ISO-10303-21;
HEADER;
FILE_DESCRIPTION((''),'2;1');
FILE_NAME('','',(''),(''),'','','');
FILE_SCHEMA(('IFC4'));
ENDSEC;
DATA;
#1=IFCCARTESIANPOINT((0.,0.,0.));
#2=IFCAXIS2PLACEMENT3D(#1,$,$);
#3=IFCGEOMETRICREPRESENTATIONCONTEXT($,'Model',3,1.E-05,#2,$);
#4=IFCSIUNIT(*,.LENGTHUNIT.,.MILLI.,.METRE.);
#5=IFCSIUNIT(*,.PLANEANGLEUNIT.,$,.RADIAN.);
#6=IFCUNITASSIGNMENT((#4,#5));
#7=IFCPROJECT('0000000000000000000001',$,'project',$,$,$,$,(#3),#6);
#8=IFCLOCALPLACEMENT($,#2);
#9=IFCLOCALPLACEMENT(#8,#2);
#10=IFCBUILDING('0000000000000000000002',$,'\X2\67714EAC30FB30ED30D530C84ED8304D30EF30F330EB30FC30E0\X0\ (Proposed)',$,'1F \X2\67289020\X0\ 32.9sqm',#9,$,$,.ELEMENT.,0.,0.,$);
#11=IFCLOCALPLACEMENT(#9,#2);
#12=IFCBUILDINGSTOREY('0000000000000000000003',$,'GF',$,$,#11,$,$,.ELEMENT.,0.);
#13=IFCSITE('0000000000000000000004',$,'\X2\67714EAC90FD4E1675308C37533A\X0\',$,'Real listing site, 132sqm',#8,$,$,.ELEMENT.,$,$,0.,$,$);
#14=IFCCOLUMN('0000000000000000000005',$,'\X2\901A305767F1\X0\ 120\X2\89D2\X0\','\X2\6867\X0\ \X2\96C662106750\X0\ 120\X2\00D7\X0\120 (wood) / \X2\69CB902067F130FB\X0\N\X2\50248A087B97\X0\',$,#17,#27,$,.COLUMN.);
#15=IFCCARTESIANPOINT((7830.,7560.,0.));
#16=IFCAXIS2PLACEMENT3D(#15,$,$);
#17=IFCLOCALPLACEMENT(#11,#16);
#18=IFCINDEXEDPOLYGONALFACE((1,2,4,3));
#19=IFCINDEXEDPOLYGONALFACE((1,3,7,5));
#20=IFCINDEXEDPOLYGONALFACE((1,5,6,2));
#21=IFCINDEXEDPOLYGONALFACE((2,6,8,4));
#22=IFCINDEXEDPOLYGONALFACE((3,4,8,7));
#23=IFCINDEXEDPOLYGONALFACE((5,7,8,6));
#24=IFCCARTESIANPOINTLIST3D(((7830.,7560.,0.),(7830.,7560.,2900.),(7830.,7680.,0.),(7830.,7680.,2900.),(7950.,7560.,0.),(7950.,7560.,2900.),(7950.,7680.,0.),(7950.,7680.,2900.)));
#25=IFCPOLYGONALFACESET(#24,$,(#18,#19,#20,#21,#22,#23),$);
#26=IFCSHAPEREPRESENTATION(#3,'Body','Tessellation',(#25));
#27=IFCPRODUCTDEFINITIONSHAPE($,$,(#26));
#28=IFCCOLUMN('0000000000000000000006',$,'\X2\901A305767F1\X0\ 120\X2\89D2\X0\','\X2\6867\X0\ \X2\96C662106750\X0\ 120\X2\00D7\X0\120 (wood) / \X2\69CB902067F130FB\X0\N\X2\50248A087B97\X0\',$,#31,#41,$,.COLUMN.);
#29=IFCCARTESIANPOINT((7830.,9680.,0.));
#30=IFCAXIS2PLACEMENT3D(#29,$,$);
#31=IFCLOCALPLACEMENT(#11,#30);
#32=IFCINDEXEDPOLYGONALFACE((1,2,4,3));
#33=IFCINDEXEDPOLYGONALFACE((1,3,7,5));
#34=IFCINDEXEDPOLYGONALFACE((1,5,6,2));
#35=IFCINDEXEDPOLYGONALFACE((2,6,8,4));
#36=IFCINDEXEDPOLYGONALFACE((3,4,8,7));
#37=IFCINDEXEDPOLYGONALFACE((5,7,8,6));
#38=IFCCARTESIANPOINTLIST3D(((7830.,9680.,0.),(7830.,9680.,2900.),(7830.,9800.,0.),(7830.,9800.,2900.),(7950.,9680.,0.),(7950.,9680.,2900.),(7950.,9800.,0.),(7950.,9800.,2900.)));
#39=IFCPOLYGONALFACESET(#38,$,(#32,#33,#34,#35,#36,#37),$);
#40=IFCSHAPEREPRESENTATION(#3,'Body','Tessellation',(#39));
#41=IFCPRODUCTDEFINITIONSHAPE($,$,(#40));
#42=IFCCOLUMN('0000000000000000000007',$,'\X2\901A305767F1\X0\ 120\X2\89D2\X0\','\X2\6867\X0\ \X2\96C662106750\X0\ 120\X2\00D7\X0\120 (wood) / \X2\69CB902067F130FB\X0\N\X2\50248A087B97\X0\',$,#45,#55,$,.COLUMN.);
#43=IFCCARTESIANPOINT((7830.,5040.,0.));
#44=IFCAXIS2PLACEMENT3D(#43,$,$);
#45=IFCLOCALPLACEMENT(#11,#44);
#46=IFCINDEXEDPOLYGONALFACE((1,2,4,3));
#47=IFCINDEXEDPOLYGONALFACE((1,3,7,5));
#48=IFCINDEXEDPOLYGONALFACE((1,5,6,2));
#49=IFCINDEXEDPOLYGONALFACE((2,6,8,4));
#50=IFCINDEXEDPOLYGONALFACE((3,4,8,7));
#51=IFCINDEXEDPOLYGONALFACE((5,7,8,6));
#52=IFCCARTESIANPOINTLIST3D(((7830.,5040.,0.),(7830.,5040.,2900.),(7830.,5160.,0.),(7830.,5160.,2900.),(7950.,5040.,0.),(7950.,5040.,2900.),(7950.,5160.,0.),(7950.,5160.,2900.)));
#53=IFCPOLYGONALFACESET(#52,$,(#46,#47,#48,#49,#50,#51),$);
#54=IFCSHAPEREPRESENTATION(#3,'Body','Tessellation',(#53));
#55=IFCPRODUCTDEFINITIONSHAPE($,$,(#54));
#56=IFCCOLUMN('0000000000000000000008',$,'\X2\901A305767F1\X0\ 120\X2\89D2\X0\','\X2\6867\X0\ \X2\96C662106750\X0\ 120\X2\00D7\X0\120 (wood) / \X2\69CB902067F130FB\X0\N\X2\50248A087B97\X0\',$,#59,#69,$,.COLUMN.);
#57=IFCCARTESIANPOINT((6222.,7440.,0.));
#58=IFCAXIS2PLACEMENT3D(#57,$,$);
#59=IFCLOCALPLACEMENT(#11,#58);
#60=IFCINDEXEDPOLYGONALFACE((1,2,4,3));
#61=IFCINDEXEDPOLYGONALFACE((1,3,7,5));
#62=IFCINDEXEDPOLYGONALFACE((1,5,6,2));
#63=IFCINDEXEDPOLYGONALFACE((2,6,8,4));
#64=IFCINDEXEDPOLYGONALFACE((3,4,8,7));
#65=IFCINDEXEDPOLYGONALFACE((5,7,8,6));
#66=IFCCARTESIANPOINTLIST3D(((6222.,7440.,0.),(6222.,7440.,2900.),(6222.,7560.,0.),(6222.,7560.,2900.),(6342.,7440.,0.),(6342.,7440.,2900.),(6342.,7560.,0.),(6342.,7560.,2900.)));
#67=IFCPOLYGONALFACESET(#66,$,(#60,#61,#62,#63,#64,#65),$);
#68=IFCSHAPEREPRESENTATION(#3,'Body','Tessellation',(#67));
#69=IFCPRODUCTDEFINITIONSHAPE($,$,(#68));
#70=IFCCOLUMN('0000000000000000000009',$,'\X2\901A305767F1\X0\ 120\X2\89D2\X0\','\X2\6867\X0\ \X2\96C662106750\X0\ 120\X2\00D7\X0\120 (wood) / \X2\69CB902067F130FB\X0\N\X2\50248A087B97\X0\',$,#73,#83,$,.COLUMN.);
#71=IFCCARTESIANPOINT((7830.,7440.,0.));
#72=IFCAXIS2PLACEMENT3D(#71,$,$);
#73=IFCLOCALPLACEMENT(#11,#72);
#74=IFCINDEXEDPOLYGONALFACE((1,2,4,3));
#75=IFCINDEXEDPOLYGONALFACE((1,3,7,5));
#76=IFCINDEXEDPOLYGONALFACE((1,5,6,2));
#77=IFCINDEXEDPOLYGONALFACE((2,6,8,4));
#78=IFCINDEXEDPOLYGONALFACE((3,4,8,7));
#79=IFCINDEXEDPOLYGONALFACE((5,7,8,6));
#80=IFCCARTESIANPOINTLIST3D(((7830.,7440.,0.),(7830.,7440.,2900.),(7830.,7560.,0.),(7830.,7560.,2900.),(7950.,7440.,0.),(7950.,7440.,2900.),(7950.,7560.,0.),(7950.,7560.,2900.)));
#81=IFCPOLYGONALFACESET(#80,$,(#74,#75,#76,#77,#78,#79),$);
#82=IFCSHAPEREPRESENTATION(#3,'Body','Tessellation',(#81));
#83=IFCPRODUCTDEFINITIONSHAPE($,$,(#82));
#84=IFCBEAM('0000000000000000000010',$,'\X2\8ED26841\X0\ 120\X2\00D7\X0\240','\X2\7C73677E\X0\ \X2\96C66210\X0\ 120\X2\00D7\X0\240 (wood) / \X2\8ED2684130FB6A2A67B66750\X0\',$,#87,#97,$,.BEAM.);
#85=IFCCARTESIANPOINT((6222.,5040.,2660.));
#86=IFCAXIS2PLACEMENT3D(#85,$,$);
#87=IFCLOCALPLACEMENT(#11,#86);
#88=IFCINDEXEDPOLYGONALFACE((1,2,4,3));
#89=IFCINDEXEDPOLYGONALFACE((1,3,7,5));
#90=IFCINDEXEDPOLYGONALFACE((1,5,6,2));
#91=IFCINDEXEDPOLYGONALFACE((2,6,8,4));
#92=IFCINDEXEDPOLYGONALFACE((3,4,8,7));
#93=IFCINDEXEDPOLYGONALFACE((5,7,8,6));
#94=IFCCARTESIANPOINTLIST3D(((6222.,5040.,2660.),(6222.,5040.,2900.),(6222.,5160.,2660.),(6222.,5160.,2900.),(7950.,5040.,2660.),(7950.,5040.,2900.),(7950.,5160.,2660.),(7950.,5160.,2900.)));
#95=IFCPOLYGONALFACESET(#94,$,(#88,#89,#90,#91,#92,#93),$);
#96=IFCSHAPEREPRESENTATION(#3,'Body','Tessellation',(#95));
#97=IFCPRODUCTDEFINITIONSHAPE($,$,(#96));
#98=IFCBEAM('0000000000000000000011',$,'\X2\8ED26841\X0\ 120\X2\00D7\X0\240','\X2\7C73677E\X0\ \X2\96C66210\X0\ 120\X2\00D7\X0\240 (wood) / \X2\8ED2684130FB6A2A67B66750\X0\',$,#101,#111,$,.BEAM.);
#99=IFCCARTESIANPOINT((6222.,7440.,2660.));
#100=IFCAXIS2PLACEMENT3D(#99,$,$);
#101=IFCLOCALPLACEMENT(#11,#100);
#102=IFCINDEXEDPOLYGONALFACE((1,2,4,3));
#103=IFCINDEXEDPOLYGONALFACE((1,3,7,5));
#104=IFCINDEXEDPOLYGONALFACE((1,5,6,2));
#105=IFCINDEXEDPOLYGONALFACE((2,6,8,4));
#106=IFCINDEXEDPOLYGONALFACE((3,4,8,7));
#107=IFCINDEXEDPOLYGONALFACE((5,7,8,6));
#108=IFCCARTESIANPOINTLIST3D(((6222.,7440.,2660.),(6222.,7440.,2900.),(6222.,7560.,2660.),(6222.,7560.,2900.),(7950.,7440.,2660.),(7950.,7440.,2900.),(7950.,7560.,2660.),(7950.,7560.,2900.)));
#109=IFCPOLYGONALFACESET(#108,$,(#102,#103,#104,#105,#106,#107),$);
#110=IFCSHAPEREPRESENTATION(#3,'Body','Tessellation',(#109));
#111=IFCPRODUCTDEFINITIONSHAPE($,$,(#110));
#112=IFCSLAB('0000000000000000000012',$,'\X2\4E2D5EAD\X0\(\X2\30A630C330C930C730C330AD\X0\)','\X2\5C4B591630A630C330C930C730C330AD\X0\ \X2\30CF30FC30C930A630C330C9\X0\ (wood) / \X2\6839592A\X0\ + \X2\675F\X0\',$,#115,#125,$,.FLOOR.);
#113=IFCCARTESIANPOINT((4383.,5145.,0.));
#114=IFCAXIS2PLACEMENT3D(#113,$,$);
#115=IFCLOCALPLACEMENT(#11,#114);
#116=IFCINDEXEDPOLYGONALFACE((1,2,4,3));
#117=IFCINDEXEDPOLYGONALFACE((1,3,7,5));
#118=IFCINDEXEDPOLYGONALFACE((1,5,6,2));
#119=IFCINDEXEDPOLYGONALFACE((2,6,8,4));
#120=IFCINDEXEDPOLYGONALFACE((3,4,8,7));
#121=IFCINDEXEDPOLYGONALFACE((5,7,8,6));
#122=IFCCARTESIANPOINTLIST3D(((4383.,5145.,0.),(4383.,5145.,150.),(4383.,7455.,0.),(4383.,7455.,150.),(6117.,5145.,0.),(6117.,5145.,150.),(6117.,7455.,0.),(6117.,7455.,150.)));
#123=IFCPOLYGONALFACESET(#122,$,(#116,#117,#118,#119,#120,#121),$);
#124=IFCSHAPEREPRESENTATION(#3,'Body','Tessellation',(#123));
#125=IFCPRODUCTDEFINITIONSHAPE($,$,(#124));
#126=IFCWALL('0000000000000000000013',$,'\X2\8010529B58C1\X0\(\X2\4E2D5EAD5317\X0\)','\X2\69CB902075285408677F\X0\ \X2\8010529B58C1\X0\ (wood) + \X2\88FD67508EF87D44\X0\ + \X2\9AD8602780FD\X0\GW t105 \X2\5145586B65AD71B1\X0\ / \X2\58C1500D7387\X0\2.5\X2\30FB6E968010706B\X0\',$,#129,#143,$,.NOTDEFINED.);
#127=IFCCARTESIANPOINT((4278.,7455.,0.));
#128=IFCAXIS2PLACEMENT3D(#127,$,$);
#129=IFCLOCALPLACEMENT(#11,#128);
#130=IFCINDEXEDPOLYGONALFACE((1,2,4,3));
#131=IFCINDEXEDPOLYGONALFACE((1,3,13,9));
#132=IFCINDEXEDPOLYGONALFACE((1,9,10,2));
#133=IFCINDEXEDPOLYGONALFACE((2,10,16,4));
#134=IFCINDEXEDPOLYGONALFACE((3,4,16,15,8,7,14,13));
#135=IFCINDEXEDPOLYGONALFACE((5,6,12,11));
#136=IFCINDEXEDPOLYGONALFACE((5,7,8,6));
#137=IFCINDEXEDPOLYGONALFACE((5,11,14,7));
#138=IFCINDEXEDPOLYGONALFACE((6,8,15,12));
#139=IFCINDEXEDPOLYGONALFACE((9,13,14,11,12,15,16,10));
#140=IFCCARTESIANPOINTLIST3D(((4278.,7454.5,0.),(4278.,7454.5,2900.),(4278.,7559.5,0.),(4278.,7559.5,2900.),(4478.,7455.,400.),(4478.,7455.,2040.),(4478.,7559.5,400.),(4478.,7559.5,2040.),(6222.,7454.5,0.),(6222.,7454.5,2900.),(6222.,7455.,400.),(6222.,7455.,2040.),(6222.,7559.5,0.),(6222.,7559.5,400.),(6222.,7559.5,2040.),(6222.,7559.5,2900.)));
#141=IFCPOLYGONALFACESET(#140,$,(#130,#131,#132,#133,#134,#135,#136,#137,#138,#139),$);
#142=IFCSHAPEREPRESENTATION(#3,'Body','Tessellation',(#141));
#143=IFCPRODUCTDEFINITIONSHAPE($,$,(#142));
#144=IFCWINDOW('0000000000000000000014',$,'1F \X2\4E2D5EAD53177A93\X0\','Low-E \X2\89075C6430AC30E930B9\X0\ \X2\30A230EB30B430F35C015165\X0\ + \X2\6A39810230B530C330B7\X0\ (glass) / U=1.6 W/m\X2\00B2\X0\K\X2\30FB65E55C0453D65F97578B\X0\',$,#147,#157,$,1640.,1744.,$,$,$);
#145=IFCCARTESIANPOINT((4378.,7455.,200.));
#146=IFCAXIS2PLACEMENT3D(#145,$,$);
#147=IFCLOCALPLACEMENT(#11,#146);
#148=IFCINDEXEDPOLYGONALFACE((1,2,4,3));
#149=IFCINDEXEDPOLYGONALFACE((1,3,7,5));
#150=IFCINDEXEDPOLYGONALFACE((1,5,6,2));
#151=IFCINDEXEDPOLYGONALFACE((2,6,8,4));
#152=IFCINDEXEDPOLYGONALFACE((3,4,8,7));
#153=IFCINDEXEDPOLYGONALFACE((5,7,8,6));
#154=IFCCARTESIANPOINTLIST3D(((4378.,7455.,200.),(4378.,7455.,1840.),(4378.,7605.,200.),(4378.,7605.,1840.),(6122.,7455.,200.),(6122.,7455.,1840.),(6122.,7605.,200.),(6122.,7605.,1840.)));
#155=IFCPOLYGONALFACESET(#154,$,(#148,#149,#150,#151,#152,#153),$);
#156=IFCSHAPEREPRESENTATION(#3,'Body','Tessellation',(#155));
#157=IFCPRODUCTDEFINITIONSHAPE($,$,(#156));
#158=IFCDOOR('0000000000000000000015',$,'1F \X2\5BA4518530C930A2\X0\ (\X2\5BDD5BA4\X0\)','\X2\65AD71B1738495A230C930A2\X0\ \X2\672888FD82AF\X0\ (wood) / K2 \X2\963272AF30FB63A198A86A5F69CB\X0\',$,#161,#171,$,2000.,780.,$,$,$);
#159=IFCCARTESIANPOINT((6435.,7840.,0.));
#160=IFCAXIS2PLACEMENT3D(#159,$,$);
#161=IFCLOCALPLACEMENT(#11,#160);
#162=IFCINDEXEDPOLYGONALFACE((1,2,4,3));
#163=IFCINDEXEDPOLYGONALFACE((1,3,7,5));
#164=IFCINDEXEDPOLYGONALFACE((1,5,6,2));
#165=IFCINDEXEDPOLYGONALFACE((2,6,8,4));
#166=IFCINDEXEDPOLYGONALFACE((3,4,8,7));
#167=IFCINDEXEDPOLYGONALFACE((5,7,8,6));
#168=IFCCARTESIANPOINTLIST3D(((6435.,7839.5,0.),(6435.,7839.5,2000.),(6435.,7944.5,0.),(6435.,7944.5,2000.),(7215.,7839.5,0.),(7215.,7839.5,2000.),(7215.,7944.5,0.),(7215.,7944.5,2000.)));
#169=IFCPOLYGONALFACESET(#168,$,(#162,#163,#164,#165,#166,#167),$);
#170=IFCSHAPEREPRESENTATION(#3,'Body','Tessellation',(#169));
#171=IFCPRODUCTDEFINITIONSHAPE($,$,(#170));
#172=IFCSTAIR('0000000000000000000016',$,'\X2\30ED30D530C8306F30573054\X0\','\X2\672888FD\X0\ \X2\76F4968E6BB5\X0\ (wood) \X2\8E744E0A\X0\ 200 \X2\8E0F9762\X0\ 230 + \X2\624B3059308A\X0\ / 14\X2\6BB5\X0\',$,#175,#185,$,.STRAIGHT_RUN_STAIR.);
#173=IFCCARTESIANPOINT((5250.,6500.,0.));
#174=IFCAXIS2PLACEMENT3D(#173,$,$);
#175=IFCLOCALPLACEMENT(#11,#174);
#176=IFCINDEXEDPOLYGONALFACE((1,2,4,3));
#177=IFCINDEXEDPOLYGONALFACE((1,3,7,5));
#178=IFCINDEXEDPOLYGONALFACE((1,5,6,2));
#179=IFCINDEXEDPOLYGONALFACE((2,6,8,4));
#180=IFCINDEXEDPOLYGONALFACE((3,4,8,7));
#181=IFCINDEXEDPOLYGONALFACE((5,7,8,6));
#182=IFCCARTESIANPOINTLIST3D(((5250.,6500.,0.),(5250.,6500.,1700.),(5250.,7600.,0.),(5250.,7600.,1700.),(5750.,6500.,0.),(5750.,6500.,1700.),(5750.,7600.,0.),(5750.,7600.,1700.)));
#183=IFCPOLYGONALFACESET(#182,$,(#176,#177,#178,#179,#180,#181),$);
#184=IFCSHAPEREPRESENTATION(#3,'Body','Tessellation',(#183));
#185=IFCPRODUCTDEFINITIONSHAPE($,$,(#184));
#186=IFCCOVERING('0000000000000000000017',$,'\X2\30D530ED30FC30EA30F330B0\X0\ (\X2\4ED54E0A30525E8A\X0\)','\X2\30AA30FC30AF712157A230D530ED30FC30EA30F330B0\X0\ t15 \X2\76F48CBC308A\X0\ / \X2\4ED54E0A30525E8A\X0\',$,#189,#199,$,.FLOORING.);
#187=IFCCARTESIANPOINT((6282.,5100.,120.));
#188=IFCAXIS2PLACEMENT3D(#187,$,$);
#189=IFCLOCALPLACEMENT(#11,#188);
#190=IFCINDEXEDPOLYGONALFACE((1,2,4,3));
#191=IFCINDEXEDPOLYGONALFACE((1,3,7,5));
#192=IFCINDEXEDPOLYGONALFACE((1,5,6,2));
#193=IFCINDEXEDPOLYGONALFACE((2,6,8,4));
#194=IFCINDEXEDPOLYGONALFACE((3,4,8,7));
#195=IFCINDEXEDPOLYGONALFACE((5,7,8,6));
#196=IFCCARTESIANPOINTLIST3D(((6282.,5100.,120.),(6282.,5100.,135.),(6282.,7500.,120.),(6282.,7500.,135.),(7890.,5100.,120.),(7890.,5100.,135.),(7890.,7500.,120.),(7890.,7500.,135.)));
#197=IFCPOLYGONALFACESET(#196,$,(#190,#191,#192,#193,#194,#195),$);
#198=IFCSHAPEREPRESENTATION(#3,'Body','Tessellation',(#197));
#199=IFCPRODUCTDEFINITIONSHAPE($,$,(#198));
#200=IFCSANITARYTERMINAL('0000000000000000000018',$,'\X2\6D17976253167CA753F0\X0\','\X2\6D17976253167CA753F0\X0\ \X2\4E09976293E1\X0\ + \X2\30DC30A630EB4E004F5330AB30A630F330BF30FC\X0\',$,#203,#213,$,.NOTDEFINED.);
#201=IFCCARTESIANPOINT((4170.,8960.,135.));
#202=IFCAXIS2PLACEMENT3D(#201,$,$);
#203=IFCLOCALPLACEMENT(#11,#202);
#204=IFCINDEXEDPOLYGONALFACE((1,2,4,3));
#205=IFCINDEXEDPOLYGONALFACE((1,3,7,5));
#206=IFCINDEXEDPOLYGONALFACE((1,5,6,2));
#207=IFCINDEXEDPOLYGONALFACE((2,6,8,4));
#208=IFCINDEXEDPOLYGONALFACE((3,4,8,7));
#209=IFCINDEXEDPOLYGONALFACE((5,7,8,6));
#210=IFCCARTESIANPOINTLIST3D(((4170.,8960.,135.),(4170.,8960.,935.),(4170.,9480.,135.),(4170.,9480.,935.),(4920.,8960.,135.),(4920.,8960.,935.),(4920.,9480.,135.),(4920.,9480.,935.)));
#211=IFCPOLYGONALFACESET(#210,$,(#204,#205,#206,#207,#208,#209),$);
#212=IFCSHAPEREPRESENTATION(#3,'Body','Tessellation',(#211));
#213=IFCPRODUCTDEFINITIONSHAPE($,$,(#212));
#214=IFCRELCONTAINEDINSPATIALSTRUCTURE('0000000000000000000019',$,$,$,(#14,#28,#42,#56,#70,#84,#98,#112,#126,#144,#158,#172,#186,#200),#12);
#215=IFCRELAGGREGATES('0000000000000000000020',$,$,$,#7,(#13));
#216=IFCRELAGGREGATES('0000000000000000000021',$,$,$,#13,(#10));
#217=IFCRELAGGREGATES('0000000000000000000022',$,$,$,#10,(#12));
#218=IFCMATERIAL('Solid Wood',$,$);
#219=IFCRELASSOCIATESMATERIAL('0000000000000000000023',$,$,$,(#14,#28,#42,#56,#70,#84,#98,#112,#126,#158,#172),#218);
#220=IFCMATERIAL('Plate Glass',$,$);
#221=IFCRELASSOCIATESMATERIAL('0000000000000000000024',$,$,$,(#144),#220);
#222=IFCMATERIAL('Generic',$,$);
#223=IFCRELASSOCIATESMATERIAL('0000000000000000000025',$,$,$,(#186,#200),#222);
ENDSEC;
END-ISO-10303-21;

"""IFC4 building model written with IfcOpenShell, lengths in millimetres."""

from ifc_helpers import new_model, si_unit, frame, frame_2d, origin, place, context, project, spatial, rectangle, extrude, material, element, fill, save


model = new_model("IFC4")

# Units and contexts
model_context = context("Model", 3, precision=1e-05, world=origin())
ifc_project = project(units=[si_unit("LENGTHUNIT", "METRE", prefix="MILLI"), si_unit("PLANEANGLEUNIT", "RADIAN")], contexts=[model_context])

# Site, building, storey
site_placement = place(None, origin())
site = spatial("IfcSite", under=ifc_project, at=site_placement, Name="東京都世田谷区", ObjectType="Real listing site, 132sqm", CompositionType="ELEMENT", RefElevation=0.0)
building_placement = place(site_placement, origin())
building = spatial("IfcBuilding", under=site, at=building_placement, Name="東京・ロフト付きワンルーム (Proposed)", ObjectType="1F 木造 32.9sqm", CompositionType="ELEMENT", ElevationOfRefHeight=0.0, ElevationOfTerrain=0.0)
storey_placement = place(building_placement, origin())
storey = spatial("IfcBuildingStorey", under=building, at=storey_placement, Name="GF", CompositionType="ELEMENT", Elevation=0.0)

# Columns
ifc_material_1 = material(Name="Solid Wood")
column_1_placement = place(storey_placement, frame((7830.0, 7560.0, 0.0)))
element("IfcColumn", 1, at=column_1_placement, inside=storey, material=ifc_material_1, Name="通し柱 120角", Description="桧 集成材 120×120 (wood) / 構造柱・N値計算", PredefinedType="COLUMN", context=model_context, shape_type="SweptSolid", body=[
    extrude(rectangle(XDim=120.0, YDim=120.0, at=frame_2d((60.0, 60.0))), frame((7830.0, 7560.0, 0.0)), (0.0, 0.0, 1.0), 2900.0),
])
column_2_placement = place(storey_placement, frame((7830.0, 9680.0, 0.0)))
element("IfcColumn", 2, at=column_2_placement, inside=storey, material=ifc_material_1, Name="通し柱 120角", Description="桧 集成材 120×120 (wood) / 構造柱・N値計算", PredefinedType="COLUMN", context=model_context, shape_type="SweptSolid", body=[
    extrude(rectangle(XDim=120.0, YDim=120.0, at=frame_2d((60.0, 60.0))), frame((7830.0, 9680.0, 0.0)), (0.0, 0.0, 1.0), 2900.0),
])
column_3_placement = place(storey_placement, frame((7830.0, 5040.0, 0.0)))
element("IfcColumn", 3, at=column_3_placement, inside=storey, material=ifc_material_1, Name="通し柱 120角", Description="桧 集成材 120×120 (wood) / 構造柱・N値計算", PredefinedType="COLUMN", context=model_context, shape_type="SweptSolid", body=[
    extrude(rectangle(XDim=120.0, YDim=120.0, at=frame_2d((60.0, 60.0))), frame((7830.0, 5040.0, 0.0)), (0.0, 0.0, 1.0), 2900.0),
])
column_4_placement = place(storey_placement, frame((6222.0, 7440.0, 0.0)))
element("IfcColumn", 4, at=column_4_placement, inside=storey, material=ifc_material_1, Name="通し柱 120角", Description="桧 集成材 120×120 (wood) / 構造柱・N値計算", PredefinedType="COLUMN", context=model_context, shape_type="SweptSolid", body=[
    extrude(rectangle(XDim=120.0, YDim=120.0, at=frame_2d((60.0, 60.0))), frame((6222.0, 7440.0, 0.0)), (0.0, 0.0, 1.0), 2900.0),
])
column_5_placement = place(storey_placement, frame((7830.0, 7440.0, 0.0)))
element("IfcColumn", 5, at=column_5_placement, inside=storey, material=ifc_material_1, Name="通し柱 120角", Description="桧 集成材 120×120 (wood) / 構造柱・N値計算", PredefinedType="COLUMN", context=model_context, shape_type="SweptSolid", body=[
    extrude(rectangle(XDim=120.0, YDim=120.0, at=frame_2d((60.0, 60.0))), frame((7830.0, 7440.0, 0.0)), (0.0, 0.0, 1.0), 2900.0),
])

# Beams
beam_1_placement = place(storey_placement, frame((6222.0, 5040.0, 2660.0)))
element("IfcBeam", 6, at=beam_1_placement, inside=storey, material=ifc_material_1, Name="軒桁 120×240", Description="米松 集成 120×240 (wood) / 軒桁・横架材", PredefinedType="BEAM", context=model_context, shape_type="SweptSolid", body=[
    extrude(rectangle(XDim=1728.0, YDim=120.0, at=frame_2d((864.0, 60.0))), frame((6222.0, 5040.0, 2660.0)), (0.0, 0.0, 1.0), 240.0),
])
beam_2_placement = place(storey_placement, frame((6222.0, 7440.0, 2660.0)))
element("IfcBeam", 7, at=beam_2_placement, inside=storey, material=ifc_material_1, Name="軒桁 120×240", Description="米松 集成 120×240 (wood) / 軒桁・横架材", PredefinedType="BEAM", context=model_context, shape_type="SweptSolid", body=[
    extrude(rectangle(XDim=1728.0, YDim=120.0, at=frame_2d((864.0, 60.0))), frame((6222.0, 7440.0, 2660.0)), (0.0, 0.0, 1.0), 240.0),
])

# Slab
slab_placement = place(storey_placement, frame((4383.0, 5145.0, 0.0)))
element("IfcSlab", 8, at=slab_placement, inside=storey, material=ifc_material_1, Name="中庭(ウッドデッキ)", Description="屋外ウッドデッキ ハードウッド (wood) / 根太 + 束", PredefinedType="FLOOR", context=model_context, shape_type="SweptSolid", body=[
    extrude(rectangle(XDim=1734.0, YDim=2310.0, at=frame_2d((867.0, 1155.0))), frame((4383.0, 5145.0, 0.0)), (0.0, 0.0, 1.0), 150.0),
])

# Wall, opening, window
wall_1_placement = place(storey_placement, frame((4278.0, 7455.0, 0.0)))
wall_1 = element("IfcWall", 9, at=wall_1_placement, inside=storey, material=ifc_material_1, Name="耐力壁(中庭北)", Description="構造用合板 耐力壁 (wood) + 製材軸組 + 高性能GW t105 充填断熱 / 壁倍率2.5・準耐火", PredefinedType="NOTDEFINED", context=model_context, shape_type="SweptSolid", body=[
    extrude(rectangle(XDim=1944.0, YDim=105.0, at=frame_2d((972.0, 52.0))), frame((4278.0, 7455.0, 0.0)), (0.0, 0.0, 1.0), 2900.0),
])
opening_placement = place(storey_placement, frame((4378.0, 7455.0, 200.0)))
opening = element("IfcOpeningElement", 10, at=opening_placement, cuts=wall_1, PredefinedType="NOTDEFINED", context=model_context, shape_type="SweptSolid", body=[
    extrude(rectangle(XDim=1744.0, YDim=150.0, at=frame_2d((872.0, 75.0))), frame((4378.0, 7455.0, 200.0)), (0.0, 0.0, 1.0), 1640.0),
])
ifc_material_2 = material(Name="Plate Glass")
window_placement = place(storey_placement, frame((4378.0, 7455.0, 200.0)))
window = element("IfcWindow", 11, at=window_placement, inside=storey, material=ifc_material_2, Name="1F 中庭北窓", Description="Low-E 複層ガラス アルゴン封入 + 樹脂サッシ (glass) / U=1.6 W/m²K・日射取得型", OverallHeight=1640.0, OverallWidth=1744.0, context=model_context, shape_type="SweptSolid", body=[
    extrude(rectangle(XDim=1744.0, YDim=150.0, at=frame_2d((872.0, 75.0))), frame((4378.0, 7455.0, 200.0)), (0.0, 0.0, 1.0), 1640.0),
])
fill(opening, window)

# Door
door_placement = place(storey_placement, frame((6435.0, 7840.0, 0.0)))
element("IfcDoor", 12, at=door_placement, inside=storey, material=ifc_material_1, Name="1F 室内ドア (寝室)", Description="断熱玄関ドア 木製芯 (wood) / K2 防犯・採風機構", OverallHeight=2000.0, OverallWidth=780.0, context=model_context, shape_type="SweptSolid", body=[
    extrude(rectangle(XDim=780.0, YDim=105.0, at=frame_2d((390.0, 52.0))), frame((6435.0, 7840.0, 0.0)), (0.0, 0.0, 1.0), 2000.0),
])

# Stair
stair_placement = place(storey_placement, frame((5250.0, 6500.0, 0.0)))
element("IfcStair", 13, at=stair_placement, inside=storey, material=ifc_material_1, Name="ロフトはしご", Description="木製 直階段 (wood) 蹴上 200 踏面 230 + 手すり / 14段", PredefinedType="STRAIGHT_RUN_STAIR", context=model_context, shape_type="SweptSolid", body=[
    extrude(rectangle(XDim=500.0, YDim=1100.0, at=frame_2d((250.0, 550.0))), frame((5250.0, 6500.0, 0.0)), (0.0, 0.0, 1.0), 1700.0),
])

# Covering
ifc_material_3 = material(Name="Generic")
covering_placement = place(storey_placement, frame((6282.0, 5100.0, 120.0)))
element("IfcCovering", 14, at=covering_placement, inside=storey, material=ifc_material_3, Name="フローリング (仕上げ床)", Description="オーク無垢フローリング t15 直貼り / 仕上げ床", PredefinedType="FLOORING", context=model_context, shape_type="SweptSolid", body=[
    extrude(rectangle(XDim=1608.0, YDim=2400.0, at=frame_2d((804.0, 1200.0))), frame((6282.0, 5100.0, 120.0)), (0.0, 0.0, 1.0), 15.0),
])

# Sanitary terminal
sanitary_terminal_1_placement = place(storey_placement, frame((4170.0, 8960.0, 135.0)))
element("IfcSanitaryTerminal", 15, at=sanitary_terminal_1_placement, inside=storey, material=ifc_material_3, Name="洗面化粧台", Description="洗面化粧台 三面鏡 + ボウル一体カウンター", PredefinedType="NOTDEFINED", context=model_context, shape_type="SweptSolid", body=[
    extrude(rectangle(XDim=750.0, YDim=520.0, at=frame_2d((375.0, 260.0))), frame((4170.0, 8960.0, 135.0)), (0.0, 0.0, 1.0), 800.0),
])

save(model, "model.ifc")
